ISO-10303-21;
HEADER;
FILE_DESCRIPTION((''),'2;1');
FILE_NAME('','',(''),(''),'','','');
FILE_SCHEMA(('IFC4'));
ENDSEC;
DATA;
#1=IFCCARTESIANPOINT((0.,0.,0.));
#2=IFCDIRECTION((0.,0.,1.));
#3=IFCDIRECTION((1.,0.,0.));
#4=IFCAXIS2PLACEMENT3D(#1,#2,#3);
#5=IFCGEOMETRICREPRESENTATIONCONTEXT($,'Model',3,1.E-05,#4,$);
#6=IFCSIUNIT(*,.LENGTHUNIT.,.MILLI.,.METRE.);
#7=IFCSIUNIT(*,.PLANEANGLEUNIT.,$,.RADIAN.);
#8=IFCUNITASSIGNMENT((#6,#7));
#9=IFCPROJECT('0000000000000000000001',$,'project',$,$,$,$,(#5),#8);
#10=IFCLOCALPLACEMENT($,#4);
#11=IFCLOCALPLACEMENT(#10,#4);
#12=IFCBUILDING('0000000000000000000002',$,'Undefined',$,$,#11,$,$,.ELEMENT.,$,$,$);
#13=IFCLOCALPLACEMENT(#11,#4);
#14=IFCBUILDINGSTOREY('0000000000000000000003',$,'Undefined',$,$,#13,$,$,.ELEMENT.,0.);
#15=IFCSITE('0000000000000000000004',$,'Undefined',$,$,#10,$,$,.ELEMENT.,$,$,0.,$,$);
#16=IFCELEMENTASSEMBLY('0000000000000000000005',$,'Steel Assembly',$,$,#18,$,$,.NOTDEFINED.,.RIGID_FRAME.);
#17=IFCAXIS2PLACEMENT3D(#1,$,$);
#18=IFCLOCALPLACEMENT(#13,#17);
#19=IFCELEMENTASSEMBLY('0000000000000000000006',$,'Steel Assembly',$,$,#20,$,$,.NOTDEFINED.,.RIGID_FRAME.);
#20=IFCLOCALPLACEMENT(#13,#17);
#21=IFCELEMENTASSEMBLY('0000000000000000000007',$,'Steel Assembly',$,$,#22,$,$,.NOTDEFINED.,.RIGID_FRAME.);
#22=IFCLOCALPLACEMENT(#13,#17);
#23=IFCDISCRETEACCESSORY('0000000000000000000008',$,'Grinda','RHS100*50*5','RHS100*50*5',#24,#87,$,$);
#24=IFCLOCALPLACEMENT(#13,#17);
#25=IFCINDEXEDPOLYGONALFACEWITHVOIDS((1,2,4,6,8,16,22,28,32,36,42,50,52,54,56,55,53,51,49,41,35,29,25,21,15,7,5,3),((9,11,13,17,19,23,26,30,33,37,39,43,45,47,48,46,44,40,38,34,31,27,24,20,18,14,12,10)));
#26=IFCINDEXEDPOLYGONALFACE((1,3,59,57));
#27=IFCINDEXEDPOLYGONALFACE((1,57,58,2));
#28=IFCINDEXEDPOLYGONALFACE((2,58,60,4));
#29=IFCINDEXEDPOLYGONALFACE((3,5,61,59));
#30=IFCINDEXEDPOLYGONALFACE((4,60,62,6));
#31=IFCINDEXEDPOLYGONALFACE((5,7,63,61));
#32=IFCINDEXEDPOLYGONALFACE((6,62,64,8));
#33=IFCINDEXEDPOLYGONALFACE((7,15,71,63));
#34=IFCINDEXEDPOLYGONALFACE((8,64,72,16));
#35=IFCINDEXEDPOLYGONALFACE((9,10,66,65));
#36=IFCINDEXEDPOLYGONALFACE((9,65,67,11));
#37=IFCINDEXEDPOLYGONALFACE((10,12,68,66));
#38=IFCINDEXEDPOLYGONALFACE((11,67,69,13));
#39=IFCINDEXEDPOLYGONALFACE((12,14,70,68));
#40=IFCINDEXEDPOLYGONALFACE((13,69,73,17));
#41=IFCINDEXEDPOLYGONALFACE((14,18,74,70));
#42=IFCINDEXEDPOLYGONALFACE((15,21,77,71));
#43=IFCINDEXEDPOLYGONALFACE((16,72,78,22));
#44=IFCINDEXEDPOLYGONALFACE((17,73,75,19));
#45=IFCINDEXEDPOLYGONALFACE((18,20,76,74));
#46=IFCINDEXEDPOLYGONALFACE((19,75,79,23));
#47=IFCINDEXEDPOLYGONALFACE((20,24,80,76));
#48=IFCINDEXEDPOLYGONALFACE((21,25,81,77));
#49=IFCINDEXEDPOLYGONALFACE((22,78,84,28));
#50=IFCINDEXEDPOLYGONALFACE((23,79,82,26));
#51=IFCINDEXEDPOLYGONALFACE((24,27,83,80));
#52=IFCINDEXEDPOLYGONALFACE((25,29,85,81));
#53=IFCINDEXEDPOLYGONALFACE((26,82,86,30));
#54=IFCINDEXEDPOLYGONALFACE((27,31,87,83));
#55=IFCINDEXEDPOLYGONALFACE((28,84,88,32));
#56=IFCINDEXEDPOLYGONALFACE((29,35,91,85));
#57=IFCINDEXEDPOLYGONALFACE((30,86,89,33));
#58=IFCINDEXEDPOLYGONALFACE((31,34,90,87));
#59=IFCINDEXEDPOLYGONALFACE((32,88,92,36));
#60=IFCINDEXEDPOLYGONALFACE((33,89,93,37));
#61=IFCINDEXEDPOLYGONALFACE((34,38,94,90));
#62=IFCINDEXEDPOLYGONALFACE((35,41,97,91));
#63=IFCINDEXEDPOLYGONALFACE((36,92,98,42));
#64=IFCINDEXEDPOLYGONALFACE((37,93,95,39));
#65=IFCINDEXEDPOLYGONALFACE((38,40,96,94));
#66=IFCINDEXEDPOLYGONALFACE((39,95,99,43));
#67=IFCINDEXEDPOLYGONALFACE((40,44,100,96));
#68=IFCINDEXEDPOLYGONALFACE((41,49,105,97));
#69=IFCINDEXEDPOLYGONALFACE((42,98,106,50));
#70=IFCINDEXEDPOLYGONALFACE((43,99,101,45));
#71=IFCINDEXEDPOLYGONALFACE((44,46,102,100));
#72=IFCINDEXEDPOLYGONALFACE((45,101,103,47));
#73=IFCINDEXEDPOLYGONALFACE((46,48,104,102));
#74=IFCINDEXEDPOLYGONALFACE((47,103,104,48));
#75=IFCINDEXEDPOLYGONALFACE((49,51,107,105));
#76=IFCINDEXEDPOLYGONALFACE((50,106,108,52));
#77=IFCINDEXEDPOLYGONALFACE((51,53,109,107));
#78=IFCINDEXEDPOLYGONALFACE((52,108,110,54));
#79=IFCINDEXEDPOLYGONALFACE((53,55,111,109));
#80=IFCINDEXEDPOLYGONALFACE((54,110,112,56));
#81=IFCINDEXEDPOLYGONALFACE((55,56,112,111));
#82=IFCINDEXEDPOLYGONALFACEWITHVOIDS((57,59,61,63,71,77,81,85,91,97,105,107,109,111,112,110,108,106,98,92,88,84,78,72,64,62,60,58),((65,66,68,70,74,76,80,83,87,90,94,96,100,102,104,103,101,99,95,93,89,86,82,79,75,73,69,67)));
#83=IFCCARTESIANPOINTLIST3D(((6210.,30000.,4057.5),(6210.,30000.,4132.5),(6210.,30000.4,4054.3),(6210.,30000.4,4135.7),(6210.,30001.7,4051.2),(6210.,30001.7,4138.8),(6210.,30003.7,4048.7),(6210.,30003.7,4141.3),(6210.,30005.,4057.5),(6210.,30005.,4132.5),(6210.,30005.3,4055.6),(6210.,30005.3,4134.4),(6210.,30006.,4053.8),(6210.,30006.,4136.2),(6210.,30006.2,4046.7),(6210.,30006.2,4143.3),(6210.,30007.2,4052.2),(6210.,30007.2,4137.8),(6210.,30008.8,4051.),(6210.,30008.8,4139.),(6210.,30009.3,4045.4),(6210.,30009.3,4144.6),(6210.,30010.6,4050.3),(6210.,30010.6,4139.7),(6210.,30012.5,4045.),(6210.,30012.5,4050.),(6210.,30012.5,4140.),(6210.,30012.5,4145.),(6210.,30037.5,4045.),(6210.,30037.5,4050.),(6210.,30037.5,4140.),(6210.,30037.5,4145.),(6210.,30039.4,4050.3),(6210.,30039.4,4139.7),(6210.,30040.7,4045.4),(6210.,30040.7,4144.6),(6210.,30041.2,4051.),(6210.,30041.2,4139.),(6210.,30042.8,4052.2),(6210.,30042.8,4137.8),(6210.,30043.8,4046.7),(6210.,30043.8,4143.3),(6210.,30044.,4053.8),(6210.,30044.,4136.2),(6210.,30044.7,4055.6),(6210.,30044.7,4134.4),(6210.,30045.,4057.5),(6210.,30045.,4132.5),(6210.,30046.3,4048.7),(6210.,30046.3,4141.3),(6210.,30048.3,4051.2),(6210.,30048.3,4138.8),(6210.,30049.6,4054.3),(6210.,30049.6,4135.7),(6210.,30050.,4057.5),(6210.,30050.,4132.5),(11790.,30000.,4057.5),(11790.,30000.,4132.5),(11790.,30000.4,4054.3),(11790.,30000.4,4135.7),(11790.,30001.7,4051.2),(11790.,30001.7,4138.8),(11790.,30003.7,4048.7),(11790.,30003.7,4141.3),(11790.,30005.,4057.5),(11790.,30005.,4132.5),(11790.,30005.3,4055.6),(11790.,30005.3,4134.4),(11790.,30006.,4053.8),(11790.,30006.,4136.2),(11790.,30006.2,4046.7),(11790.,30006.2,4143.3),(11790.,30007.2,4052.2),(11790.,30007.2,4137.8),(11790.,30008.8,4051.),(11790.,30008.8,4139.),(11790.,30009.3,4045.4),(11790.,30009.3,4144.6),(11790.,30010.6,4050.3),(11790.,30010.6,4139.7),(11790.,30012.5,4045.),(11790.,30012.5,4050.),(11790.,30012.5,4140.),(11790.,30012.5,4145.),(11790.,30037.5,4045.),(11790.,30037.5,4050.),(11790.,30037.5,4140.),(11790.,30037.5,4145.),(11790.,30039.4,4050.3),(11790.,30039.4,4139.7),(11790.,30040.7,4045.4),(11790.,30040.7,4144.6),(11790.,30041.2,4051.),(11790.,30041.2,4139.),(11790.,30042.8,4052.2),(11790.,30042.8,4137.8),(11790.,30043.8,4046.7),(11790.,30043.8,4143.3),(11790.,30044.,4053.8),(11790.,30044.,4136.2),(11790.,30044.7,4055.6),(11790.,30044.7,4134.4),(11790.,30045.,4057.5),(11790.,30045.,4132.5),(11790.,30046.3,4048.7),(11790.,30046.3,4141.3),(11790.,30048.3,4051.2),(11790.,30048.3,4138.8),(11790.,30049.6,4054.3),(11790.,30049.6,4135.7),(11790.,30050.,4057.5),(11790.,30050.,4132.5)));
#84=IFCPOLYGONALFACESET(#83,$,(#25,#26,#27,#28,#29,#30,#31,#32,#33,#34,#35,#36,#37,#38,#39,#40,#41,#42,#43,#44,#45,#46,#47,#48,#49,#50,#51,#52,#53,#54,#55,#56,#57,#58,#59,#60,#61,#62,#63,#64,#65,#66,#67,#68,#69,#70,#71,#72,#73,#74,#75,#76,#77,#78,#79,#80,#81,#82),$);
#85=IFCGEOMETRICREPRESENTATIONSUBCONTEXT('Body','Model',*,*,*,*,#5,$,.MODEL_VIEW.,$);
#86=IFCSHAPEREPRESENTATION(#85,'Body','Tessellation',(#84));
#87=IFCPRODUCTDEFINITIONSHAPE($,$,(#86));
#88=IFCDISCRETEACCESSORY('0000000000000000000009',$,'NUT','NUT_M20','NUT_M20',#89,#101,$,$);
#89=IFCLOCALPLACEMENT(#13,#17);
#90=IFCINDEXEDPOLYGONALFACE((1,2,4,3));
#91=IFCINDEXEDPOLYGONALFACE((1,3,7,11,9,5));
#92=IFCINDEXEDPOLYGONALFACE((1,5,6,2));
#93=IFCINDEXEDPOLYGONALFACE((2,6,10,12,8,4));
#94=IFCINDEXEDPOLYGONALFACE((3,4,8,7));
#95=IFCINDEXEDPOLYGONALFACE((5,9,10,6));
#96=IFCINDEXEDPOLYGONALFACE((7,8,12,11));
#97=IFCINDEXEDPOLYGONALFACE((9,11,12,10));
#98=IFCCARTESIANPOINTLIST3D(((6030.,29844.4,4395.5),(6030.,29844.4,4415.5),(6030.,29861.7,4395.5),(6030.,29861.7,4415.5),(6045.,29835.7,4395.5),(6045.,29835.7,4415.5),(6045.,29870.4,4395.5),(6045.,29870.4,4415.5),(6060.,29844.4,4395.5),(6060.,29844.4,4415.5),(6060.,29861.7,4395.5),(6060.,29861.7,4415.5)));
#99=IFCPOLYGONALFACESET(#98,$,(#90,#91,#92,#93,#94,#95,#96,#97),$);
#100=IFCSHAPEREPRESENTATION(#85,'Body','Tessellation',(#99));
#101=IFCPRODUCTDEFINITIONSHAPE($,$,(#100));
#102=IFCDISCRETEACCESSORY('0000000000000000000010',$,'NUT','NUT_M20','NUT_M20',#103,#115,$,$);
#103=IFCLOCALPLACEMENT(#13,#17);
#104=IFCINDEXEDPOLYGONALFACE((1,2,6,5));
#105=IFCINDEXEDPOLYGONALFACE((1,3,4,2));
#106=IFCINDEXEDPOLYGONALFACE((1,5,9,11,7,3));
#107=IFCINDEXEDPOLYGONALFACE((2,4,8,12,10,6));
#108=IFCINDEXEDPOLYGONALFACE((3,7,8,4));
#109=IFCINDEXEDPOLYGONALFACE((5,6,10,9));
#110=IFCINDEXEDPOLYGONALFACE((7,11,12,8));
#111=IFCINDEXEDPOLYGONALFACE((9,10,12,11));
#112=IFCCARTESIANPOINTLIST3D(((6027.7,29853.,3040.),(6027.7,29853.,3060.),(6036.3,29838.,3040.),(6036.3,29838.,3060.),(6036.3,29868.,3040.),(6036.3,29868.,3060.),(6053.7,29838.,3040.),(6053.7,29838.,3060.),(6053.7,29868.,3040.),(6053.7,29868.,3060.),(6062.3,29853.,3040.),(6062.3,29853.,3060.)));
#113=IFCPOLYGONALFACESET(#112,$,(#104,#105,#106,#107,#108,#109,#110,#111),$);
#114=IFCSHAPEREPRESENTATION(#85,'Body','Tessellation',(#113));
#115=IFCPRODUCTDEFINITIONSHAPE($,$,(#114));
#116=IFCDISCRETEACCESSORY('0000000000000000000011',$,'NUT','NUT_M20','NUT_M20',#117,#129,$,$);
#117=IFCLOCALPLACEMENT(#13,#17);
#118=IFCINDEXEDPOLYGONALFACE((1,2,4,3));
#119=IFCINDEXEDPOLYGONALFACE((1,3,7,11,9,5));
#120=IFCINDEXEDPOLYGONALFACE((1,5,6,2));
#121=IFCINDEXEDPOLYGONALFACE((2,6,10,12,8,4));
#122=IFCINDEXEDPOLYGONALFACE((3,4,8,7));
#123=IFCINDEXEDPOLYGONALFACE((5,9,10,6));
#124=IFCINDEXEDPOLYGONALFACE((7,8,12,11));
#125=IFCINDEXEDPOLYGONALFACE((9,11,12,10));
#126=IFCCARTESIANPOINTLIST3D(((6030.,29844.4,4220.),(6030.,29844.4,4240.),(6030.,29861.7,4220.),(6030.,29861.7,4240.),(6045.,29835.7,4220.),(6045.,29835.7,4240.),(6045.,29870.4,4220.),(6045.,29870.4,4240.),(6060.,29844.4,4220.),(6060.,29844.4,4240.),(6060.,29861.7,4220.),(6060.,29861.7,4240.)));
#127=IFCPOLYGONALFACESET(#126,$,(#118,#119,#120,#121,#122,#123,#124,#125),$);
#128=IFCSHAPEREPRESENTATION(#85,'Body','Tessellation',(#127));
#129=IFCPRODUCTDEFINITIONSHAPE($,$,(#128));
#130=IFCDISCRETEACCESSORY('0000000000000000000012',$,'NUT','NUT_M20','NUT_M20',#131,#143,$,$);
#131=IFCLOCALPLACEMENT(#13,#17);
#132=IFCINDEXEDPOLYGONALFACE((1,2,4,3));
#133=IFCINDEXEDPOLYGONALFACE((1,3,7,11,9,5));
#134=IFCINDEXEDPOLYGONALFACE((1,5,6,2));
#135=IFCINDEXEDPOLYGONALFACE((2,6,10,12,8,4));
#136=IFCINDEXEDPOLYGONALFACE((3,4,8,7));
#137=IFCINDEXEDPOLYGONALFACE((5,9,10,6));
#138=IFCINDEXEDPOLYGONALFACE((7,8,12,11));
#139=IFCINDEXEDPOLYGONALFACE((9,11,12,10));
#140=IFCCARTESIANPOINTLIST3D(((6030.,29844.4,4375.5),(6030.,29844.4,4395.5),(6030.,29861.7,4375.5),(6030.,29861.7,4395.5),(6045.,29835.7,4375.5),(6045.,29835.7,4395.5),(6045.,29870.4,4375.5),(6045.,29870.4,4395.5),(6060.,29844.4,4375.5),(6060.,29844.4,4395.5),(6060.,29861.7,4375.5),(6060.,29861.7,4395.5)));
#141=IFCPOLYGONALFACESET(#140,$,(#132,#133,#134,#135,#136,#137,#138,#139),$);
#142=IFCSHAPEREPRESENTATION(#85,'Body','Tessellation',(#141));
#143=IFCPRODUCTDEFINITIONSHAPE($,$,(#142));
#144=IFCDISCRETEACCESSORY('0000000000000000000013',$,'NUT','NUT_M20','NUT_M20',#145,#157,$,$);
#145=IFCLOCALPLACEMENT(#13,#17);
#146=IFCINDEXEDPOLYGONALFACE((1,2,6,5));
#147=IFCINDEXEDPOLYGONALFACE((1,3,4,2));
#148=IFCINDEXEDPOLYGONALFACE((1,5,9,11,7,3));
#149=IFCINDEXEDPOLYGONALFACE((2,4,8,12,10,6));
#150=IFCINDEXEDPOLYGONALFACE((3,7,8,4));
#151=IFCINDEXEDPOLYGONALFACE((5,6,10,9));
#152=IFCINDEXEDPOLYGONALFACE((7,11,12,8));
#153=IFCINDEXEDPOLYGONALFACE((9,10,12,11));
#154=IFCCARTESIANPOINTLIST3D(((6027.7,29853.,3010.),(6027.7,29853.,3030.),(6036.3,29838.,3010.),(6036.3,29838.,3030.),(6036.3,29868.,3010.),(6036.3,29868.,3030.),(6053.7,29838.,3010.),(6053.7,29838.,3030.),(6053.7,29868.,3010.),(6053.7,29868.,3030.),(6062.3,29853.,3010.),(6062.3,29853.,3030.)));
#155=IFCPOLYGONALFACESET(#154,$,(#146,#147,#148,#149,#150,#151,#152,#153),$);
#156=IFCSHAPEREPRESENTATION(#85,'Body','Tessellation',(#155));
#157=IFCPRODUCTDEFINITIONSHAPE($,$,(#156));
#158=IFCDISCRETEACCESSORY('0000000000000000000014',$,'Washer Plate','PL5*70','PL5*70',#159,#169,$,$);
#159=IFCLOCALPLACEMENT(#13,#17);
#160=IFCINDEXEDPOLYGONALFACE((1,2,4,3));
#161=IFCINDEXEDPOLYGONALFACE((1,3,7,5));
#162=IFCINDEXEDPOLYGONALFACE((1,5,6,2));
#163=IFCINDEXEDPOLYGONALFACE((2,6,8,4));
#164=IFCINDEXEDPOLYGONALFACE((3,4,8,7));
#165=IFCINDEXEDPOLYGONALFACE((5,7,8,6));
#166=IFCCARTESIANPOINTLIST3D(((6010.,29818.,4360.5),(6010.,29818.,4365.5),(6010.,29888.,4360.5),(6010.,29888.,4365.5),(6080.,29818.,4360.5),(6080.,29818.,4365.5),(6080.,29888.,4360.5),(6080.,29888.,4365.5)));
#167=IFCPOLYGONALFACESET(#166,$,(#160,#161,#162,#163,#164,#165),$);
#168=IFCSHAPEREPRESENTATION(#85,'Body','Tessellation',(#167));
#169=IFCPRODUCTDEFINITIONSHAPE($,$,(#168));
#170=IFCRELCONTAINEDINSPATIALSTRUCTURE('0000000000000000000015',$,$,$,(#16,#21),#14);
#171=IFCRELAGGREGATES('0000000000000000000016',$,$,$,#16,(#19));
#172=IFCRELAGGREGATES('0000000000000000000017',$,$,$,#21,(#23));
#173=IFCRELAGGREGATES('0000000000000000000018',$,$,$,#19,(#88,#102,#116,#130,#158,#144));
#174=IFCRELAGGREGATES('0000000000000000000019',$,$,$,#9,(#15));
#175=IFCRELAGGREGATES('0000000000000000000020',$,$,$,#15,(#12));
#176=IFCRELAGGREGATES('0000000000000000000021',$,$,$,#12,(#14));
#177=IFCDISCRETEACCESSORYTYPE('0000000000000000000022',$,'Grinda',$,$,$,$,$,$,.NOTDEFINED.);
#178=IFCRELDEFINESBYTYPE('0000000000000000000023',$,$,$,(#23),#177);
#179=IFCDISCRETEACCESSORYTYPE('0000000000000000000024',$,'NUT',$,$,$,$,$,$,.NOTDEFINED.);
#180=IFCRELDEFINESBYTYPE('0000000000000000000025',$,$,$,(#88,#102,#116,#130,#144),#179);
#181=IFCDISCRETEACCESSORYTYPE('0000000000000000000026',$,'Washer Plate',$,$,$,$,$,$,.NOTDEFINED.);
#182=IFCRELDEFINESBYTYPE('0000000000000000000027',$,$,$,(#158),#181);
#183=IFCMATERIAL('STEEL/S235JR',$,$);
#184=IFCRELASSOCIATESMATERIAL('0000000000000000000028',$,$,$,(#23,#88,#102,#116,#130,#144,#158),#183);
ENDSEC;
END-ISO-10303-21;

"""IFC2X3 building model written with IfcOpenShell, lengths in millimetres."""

from ifc_helpers import new_model, si_unit, frame, origin_with_axes, origin_2d_with_axis, place, context, subcontext, project, spatial, polyline, hollow_rectangle, outline, extrude, material, type_object, element, aggregate, save


model = new_model("IFC2X3")

# Units and contexts
model_context = context("Model", 3, precision=1e-05, world=origin_with_axes())
body_context = subcontext(model_context, "Body", "Model", "MODEL_VIEW")
ifc_project = project(units=[si_unit("LENGTHUNIT", "METRE", prefix="MILLI"), si_unit("PLANEANGLEUNIT", "RADIAN")], contexts=[model_context])

# Site, building, storey
site_placement = place(None, origin_with_axes())
site = spatial("IfcSite", under=ifc_project, at=site_placement, Name="Undefined", CompositionType="ELEMENT", RefElevation=0.0)
building_placement = place(site_placement, origin_with_axes())
building = spatial("IfcBuilding", under=site, at=building_placement, Name="Undefined", CompositionType="ELEMENT")
storey_placement = place(building_placement, origin_with_axes())
storey = spatial("IfcBuildingStorey", under=building, at=storey_placement, Name="Undefined", CompositionType="ELEMENT", Elevation=0.0)

# Element assemblies
assembly_1_placement = place(storey_placement, origin_with_axes())
assembly_1 = element("IfcElementAssembly", 1, at=assembly_1_placement, inside=storey, Name="Steel Assembly", AssemblyPlace="NOTDEFINED", PredefinedType="RIGID_FRAME")
assembly_2_placement = place(assembly_1_placement, origin_with_axes())
assembly_2 = element("IfcElementAssembly", 2, at=assembly_2_placement, Name="Steel Assembly", AssemblyPlace="NOTDEFINED", PredefinedType="RIGID_FRAME")
aggregate(assembly_1, [assembly_2])

# Element assembly
assembly_3_placement = place(storey_placement, origin_with_axes())
assembly_3 = element("IfcElementAssembly", 3, at=assembly_3_placement, inside=storey, Name="Steel Assembly", AssemblyPlace="NOTDEFINED", PredefinedType="RIGID_FRAME")
ifc_material_1 = material(Name="STEEL/S235JR")

# Discrete accessory
discrete_accessory_type_1 = type_object("IfcDiscreteAccessoryType", Name="Grinda")
discrete_accessory_1_placement = place(assembly_3_placement, frame((11790.0, 30025.0, 4095.0), z_axis=(0.0, 0.0, 1.0), x_axis=(-1.0, 0.0, 0.0)))
discrete_accessory_1 = element("IfcDiscreteAccessory", 4, at=discrete_accessory_1_placement, type_object=discrete_accessory_type_1, material=ifc_material_1, Name="Grinda", Description="RHS100*50*5", ObjectType="RHS100*50*5", context=body_context, shape_type="SweptSolid", body=[
    extrude(hollow_rectangle(XDim=50.0, YDim=100.0, WallThickness=5.0, InnerFilletRadius=7.5, OuterFilletRadius=12.5, at=origin_2d_with_axis()), frame((5580.0, 0.0, 0.0), z_axis=(-1.0, 0.0, 0.0), x_axis=(0.0, -1.0, 0.0)), (0.0, 0.0, 1.0), 5580.0),
])

aggregate(assembly_3, [discrete_accessory_1])

# Discrete accessories
discrete_accessory_type_2 = type_object("IfcDiscreteAccessoryType", Name="NUT")
discrete_accessory_2_placement = place(assembly_2_placement, frame((6045.0, 29853.0, 4415.5), z_axis=(-1.0, 0.0, 0.0), x_axis=(0.0, 0.0, -1.0)))
discrete_accessory_2 = element("IfcDiscreteAccessory", 5, at=discrete_accessory_2_placement, type_object=discrete_accessory_type_2, material=ifc_material_1, Name="NUT", Description="NUT_M20", ObjectType="NUT_M20", context=body_context, shape_type="SweptSolid", body=[
    extrude(outline(polyline([(8.7, 15.0), (17.3, 0.0), (8.7, -15.0), (-8.7, -15.0), (-17.3, 0.0), (-8.7, 15.0), (8.7, 15.0)])), frame((20.0, 0.0, 0.0), z_axis=(-1.0, 0.0, 0.0), x_axis=(0.0, -1.0, 0.0)), (0.0, 0.0, 1.0), 20.0),
])
discrete_accessory_3_placement = place(assembly_2_placement, frame((6045.0, 29853.0, 3060.0), z_axis=(0.0, -1.0, 0.0), x_axis=(0.0, 0.0, -1.0)))
discrete_accessory_3 = element("IfcDiscreteAccessory", 6, at=discrete_accessory_3_placement, type_object=discrete_accessory_type_2, material=ifc_material_1, Name="NUT", Description="NUT_M20", ObjectType="NUT_M20", context=body_context, shape_type="SweptSolid", body=[
    extrude(outline(polyline([(8.7, 15.0), (17.3, 0.0), (8.7, -15.0), (-8.7, -15.0), (-17.3, 0.0), (-8.7, 15.0), (8.7, 15.0)])), frame((20.0, 0.0, 0.0), z_axis=(-1.0, 0.0, 0.0), x_axis=(0.0, -1.0, 0.0)), (0.0, 0.0, 1.0), 20.0),
])
discrete_accessory_4_placement = place(assembly_2_placement, frame((6045.0, 29853.0, 4240.0), z_axis=(-1.0, 0.0, 0.0), x_axis=(0.0, 0.0, -1.0)))
discrete_accessory_4 = element("IfcDiscreteAccessory", 7, at=discrete_accessory_4_placement, type_object=discrete_accessory_type_2, material=ifc_material_1, Name="NUT", Description="NUT_M20", ObjectType="NUT_M20", context=body_context, shape_type="SweptSolid", body=[
    extrude(outline(polyline([(8.7, 15.0), (17.3, 0.0), (8.7, -15.0), (-8.7, -15.0), (-17.3, 0.0), (-8.7, 15.0), (8.7, 15.0)])), frame((20.0, 0.0, 0.0), z_axis=(-1.0, 0.0, 0.0), x_axis=(0.0, -1.0, 0.0)), (0.0, 0.0, 1.0), 20.0),
])
discrete_accessory_5_placement = place(assembly_2_placement, frame((6045.0, 29853.0, 4395.5), z_axis=(-1.0, 0.0, 0.0), x_axis=(0.0, 0.0, -1.0)))
discrete_accessory_5 = element("IfcDiscreteAccessory", 8, at=discrete_accessory_5_placement, type_object=discrete_accessory_type_2, material=ifc_material_1, Name="NUT", Description="NUT_M20", ObjectType="NUT_M20", context=body_context, shape_type="SweptSolid", body=[
    extrude(outline(polyline([(8.7, 15.0), (17.3, 0.0), (8.7, -15.0), (-8.7, -15.0), (-17.3, 0.0), (-8.7, 15.0), (8.7, 15.0)])), frame((20.0, 0.0, 0.0), z_axis=(-1.0, 0.0, 0.0), x_axis=(0.0, -1.0, 0.0)), (0.0, 0.0, 1.0), 20.0),
])
discrete_accessory_6_placement = place(assembly_2_placement, frame((6045.0, 29853.0, 3030.0), z_axis=(0.0, -1.0, 0.0), x_axis=(0.0, 0.0, -1.0)))
discrete_accessory_6 = element("IfcDiscreteAccessory", 9, at=discrete_accessory_6_placement, type_object=discrete_accessory_type_2, material=ifc_material_1, Name="NUT", Description="NUT_M20", ObjectType="NUT_M20", context=body_context, shape_type="SweptSolid", body=[
    extrude(outline(polyline([(8.7, 15.0), (17.3, 0.0), (8.7, -15.0), (-8.7, -15.0), (-17.3, 0.0), (-8.7, 15.0), (8.7, 15.0)])), frame((20.0, 0.0, 0.0), z_axis=(-1.0, 0.0, 0.0), x_axis=(0.0, -1.0, 0.0)), (0.0, 0.0, 1.0), 20.0),
])
discrete_accessory_type_3 = type_object("IfcDiscreteAccessoryType", Name="Washer Plate")
discrete_accessory_7_placement = place(assembly_2_placement, frame((6080.0, 29818.0, 4363.0), z_axis=(0.0, 0.0, 1.0), x_axis=(0.0, 1.0, 0.0)))
discrete_accessory_7 = element("IfcDiscreteAccessory", 10, at=discrete_accessory_7_placement, type_object=discrete_accessory_type_3, material=ifc_material_1, Name="Washer Plate", Description="PL5*70", ObjectType="PL5*70", context=body_context, shape_type="SweptSolid", body=[
    extrude(outline(polyline([(0.0, 0.0), (70.0, 0.0), (70.0, 70.0), (0.0, 70.0), (0.0, 0.0)])), frame((0.0, 0.0, -2.5), z_axis=(0.0, 0.0, 1.0), x_axis=(1.0, 0.0, 0.0)), (0.0, 0.0, 1.0), 5.0),
])
aggregate(assembly_2, [discrete_accessory_2, discrete_accessory_3, discrete_accessory_4, discrete_accessory_5, discrete_accessory_7, discrete_accessory_6])

save(model, "model.ifc")
